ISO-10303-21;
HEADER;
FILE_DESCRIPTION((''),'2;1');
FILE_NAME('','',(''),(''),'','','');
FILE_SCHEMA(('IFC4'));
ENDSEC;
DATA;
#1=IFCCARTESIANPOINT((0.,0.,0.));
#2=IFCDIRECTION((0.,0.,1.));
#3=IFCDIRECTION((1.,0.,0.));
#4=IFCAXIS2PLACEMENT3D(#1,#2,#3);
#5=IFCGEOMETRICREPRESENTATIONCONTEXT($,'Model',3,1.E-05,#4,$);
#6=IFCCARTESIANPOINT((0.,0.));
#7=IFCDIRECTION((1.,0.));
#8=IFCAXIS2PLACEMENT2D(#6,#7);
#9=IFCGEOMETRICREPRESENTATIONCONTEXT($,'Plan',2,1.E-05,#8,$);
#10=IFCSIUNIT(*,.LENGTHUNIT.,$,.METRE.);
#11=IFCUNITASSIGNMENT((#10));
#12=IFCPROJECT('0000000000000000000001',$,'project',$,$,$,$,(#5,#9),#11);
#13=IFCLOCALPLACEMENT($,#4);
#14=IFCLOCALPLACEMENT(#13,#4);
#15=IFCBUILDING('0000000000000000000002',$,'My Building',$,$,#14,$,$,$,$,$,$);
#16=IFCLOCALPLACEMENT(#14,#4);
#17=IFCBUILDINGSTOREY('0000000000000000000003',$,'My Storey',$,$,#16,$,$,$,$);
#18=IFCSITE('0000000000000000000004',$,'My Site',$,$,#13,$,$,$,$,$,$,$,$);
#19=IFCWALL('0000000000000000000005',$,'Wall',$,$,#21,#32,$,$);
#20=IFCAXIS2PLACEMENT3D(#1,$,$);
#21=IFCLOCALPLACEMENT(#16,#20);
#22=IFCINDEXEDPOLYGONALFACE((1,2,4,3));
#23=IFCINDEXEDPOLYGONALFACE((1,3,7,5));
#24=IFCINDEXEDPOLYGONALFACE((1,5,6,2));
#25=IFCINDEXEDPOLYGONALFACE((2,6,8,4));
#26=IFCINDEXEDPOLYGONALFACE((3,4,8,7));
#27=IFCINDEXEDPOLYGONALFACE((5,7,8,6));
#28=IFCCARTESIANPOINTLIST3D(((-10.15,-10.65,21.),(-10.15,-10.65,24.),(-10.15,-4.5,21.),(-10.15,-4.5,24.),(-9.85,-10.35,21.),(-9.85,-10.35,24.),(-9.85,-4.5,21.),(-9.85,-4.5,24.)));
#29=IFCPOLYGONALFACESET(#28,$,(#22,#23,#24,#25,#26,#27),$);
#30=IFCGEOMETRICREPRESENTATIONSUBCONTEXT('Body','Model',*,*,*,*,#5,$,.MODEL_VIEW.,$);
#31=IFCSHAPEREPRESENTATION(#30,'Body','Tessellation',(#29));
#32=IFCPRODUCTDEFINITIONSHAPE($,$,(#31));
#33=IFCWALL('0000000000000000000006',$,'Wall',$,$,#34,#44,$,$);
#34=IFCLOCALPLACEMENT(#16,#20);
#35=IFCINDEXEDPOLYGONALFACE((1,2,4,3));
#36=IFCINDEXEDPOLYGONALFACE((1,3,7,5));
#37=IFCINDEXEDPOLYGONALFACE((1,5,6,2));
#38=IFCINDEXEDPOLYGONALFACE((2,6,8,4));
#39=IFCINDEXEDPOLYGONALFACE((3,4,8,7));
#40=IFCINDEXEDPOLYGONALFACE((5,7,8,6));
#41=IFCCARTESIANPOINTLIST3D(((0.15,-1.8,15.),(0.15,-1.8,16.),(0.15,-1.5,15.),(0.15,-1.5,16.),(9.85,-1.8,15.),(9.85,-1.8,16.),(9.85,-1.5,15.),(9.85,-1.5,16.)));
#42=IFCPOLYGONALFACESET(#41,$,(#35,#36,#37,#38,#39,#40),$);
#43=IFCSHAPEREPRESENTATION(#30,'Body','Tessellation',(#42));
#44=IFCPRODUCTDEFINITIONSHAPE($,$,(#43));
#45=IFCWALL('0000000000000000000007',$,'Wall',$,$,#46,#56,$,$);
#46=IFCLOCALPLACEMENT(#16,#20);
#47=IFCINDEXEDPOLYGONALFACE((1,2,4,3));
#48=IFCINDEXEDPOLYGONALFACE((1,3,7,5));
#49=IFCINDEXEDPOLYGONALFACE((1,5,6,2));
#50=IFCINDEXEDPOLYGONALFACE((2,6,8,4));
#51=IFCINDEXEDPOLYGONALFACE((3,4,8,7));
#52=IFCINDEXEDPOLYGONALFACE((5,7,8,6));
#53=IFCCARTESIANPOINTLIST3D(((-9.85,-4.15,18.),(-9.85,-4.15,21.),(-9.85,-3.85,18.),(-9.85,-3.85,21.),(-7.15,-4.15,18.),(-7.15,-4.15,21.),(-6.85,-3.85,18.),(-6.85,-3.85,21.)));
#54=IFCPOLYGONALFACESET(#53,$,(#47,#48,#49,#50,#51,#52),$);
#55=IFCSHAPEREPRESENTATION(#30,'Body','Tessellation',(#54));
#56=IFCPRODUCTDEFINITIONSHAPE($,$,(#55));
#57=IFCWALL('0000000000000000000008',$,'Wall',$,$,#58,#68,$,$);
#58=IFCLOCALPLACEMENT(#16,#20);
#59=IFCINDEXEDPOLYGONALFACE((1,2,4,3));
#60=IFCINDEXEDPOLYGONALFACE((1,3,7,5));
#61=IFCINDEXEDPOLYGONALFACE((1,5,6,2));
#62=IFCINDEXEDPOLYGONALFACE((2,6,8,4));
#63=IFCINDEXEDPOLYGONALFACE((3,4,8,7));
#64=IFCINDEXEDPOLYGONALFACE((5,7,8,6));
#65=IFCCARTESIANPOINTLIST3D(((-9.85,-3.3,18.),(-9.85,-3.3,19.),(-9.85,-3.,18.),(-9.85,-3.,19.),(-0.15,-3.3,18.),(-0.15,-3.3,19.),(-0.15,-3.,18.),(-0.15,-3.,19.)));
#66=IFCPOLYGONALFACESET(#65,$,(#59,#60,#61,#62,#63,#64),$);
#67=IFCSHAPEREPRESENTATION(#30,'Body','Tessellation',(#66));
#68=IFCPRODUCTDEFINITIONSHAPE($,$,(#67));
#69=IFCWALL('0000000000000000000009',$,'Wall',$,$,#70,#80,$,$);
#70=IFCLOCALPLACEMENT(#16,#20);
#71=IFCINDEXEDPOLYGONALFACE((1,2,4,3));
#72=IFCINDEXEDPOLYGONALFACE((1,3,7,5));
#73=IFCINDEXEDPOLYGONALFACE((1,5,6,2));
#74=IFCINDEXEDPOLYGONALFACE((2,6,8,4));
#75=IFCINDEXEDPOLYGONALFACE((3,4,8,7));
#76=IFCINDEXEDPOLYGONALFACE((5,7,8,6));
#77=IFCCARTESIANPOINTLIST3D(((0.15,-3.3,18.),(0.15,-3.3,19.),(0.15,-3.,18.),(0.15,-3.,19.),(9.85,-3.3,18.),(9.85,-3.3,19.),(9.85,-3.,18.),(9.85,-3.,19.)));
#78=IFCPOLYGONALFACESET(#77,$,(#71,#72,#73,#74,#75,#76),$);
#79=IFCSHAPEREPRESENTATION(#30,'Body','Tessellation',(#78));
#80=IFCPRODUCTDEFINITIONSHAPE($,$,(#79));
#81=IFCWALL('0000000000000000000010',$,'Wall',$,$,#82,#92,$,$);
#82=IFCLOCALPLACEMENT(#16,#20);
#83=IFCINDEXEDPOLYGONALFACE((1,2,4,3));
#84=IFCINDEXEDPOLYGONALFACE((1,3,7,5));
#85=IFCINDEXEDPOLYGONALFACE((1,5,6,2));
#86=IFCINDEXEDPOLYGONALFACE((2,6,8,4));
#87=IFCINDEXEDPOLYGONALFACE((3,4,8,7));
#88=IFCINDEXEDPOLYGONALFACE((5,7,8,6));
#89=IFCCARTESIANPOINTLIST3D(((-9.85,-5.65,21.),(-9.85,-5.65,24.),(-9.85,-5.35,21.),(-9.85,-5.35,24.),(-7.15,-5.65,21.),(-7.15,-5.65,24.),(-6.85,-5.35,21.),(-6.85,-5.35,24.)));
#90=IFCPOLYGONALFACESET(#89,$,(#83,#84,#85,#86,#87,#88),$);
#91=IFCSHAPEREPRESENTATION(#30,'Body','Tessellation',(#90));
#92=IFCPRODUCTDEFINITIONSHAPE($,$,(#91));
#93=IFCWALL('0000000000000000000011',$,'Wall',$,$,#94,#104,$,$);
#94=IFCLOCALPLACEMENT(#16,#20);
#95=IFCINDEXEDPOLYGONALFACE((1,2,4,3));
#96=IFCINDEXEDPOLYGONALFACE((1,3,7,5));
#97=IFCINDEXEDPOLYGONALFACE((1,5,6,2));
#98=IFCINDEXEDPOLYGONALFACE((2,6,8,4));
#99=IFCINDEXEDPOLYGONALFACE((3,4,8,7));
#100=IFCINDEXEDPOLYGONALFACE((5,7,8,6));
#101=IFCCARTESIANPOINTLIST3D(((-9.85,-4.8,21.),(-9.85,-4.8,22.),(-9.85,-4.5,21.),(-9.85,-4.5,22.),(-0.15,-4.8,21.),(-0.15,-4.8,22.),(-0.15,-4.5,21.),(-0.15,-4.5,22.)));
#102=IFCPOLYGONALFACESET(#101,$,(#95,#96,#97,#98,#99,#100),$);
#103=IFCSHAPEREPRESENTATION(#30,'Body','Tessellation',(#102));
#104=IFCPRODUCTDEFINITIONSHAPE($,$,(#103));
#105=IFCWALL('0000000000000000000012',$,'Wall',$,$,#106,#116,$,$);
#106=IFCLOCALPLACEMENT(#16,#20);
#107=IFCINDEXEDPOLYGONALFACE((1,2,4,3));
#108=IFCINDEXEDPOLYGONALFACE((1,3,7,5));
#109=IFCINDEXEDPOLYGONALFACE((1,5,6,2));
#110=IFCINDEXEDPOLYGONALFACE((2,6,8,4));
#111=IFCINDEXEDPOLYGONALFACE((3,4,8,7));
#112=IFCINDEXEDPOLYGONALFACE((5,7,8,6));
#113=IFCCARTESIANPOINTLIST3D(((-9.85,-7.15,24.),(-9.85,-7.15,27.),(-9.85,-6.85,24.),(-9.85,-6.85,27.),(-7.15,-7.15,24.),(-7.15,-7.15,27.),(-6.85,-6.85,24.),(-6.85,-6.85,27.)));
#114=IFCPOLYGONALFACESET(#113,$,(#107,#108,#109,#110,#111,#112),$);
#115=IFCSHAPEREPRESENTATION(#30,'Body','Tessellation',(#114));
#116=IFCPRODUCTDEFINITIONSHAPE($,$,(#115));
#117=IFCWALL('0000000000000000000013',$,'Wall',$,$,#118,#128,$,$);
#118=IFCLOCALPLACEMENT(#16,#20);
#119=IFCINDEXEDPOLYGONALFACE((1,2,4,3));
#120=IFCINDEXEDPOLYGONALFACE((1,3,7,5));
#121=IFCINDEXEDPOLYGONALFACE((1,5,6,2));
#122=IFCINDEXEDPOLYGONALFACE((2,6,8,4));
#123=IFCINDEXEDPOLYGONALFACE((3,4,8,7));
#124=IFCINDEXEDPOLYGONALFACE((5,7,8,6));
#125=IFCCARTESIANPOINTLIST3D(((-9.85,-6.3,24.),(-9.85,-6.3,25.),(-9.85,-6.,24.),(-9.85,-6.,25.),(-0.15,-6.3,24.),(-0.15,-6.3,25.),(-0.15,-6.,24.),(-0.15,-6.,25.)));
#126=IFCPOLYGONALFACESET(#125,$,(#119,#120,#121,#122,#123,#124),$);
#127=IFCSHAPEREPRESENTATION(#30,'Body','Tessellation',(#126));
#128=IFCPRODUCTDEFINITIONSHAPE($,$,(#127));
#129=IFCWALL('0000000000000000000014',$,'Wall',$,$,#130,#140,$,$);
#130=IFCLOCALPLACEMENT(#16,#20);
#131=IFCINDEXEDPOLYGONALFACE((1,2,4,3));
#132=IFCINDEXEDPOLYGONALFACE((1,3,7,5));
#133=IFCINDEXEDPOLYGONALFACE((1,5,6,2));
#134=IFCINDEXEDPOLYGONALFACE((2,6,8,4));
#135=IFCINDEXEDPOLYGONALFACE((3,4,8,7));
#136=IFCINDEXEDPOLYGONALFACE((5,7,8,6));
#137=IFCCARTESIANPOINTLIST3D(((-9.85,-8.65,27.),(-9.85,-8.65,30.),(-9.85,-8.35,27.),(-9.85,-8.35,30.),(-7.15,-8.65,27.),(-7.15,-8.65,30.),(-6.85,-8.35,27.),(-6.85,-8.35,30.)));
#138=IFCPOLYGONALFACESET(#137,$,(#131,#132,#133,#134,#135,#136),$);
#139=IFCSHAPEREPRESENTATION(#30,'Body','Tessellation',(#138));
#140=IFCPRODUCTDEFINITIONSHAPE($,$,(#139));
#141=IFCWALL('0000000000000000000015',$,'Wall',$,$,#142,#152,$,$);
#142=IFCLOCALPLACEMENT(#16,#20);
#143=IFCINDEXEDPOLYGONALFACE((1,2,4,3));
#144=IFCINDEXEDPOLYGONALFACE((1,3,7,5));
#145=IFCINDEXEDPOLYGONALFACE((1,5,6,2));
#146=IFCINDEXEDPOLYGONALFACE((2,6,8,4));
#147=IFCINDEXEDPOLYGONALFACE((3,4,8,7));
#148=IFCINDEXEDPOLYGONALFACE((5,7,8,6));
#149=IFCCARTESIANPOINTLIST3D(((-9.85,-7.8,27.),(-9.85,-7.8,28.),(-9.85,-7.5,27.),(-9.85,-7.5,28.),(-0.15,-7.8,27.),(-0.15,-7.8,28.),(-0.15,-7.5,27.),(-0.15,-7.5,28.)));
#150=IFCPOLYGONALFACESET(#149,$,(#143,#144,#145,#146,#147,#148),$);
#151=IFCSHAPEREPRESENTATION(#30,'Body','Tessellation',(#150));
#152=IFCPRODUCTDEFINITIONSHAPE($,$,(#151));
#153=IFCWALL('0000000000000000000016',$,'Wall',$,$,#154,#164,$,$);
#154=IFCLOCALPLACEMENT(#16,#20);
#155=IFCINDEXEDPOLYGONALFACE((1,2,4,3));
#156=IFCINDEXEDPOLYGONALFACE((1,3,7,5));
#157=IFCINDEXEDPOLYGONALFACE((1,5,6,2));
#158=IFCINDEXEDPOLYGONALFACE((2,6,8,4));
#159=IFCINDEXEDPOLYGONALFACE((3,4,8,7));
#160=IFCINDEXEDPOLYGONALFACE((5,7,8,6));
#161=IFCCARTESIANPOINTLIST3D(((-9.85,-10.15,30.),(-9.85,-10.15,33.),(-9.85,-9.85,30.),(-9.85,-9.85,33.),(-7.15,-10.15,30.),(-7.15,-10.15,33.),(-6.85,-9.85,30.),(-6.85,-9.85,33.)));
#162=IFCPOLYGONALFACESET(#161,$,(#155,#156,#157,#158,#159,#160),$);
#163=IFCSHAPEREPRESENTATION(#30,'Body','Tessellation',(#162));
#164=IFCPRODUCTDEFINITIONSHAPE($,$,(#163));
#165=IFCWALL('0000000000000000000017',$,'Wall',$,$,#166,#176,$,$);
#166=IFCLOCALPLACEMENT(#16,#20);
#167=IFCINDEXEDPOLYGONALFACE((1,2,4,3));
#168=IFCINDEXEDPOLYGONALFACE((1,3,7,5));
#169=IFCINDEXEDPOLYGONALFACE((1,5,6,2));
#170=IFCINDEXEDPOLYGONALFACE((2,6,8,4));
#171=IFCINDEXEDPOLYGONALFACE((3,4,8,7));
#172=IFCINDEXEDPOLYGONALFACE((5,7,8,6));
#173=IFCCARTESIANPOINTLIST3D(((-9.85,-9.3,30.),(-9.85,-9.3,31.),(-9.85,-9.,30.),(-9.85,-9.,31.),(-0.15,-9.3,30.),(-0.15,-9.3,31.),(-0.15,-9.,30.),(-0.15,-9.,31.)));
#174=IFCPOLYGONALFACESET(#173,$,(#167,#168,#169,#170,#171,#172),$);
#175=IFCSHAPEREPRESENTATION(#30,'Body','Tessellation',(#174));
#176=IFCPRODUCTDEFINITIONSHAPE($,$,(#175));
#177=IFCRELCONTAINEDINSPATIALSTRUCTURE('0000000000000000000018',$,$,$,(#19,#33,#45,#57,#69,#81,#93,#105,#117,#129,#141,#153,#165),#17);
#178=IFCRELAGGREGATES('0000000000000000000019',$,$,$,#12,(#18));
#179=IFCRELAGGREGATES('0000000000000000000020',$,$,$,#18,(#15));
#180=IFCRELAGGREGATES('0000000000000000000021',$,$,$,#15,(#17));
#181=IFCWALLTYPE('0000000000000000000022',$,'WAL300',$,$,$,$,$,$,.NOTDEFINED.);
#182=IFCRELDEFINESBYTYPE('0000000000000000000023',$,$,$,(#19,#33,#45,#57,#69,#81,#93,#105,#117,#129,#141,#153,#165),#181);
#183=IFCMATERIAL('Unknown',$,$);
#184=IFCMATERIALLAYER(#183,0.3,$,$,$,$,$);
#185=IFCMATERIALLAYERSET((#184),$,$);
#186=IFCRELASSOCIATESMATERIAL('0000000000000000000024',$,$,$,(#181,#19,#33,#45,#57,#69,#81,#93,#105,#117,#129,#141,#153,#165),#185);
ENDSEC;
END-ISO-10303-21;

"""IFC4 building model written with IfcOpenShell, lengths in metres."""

from ifc_helpers import new_model, si_unit, frame, origin_with_axes, origin_2d_with_axis, place, context, subcontext, project, spatial, line, indexed_curve, outline, extrude, material, layer, layer_set, layer_usage, type_object, element, save


model = new_model("IFC4")

# Units and contexts
model_context = context("Model", 3, precision=1e-05, world=origin_with_axes())
plan_context = context("Plan", 2, precision=1e-05, world=origin_2d_with_axis())
body_context = subcontext(model_context, "Body", "Model", "MODEL_VIEW")
ifc_project = project(units=[si_unit("LENGTHUNIT", "METRE")], contexts=[model_context, plan_context])

# Site, building, storey
site_placement = place(None, origin_with_axes())
site = spatial("IfcSite", under=ifc_project, at=site_placement, Name="My Site")
building_placement = place(site_placement, origin_with_axes())
building = spatial("IfcBuilding", under=site, at=building_placement, Name="My Building")
storey_placement = place(building_placement, origin_with_axes())
storey = spatial("IfcBuildingStorey", under=building, at=storey_placement, Name="My Storey")

# Walls
ifc_material = material(Name="Unknown")
ifc_layer = layer(ifc_material, 0.3)
ifc_layer_set = layer_set([ifc_layer])
wall_type = type_object("IfcWallType", Name="WAL300", PredefinedType="NOTDEFINED", material=ifc_layer_set)
ifc_layer_usage_1 = layer_usage(ifc_layer_set, "AXIS2", "POSITIVE", -0.15)
wall_1_placement = place(storey_placement, frame((-10.0, -10.5, 21.0), z_axis=(0.0, 0.0, 1.0), x_axis=(0.0, 1.0, 0.0)))
element("IfcWall", 1, at=wall_1_placement, inside=storey, type_object=wall_type, material=ifc_layer_usage_1, Name="Wall", context=body_context, shape_type="SweptSolid", body=[
    extrude(outline(indexed_curve([(0.15, -0.15), (-0.15, 0.15), (6.0, 0.15), (6.0, -0.15)], segments=[line(1, 2, 3, 4, 1)])), origin_with_axes(), (0.0, 0.0, 1.0), 3.0),
])
ifc_layer_usage_2 = layer_usage(ifc_layer_set, "AXIS2", "POSITIVE", -0.3)
wall_2_placement = place(storey_placement, frame((0.15, -1.5, 15.0), z_axis=(0.0, 0.0, 1.0), x_axis=(1.0, 0.0, 0.0)))
element("IfcWall", 2, at=wall_2_placement, inside=storey, type_object=wall_type, material=ifc_layer_usage_2, Name="Wall", context=body_context, shape_type="SweptSolid", body=[
    extrude(outline(indexed_curve([(0.0, -0.3), (0.0, 0.0), (9.7, 0.0), (9.7, -0.3)], segments=[line(1, 2, 3, 4, 1)])), origin_with_axes(), (0.0, 0.0, 1.0), 1.0),
])
ifc_layer_usage_3 = layer_usage(ifc_layer_set, "AXIS2", "POSITIVE", -0.15)
wall_3_placement = place(storey_placement, frame((-10.0, -4.0, 18.0), z_axis=(0.0, 0.0, 1.0), x_axis=(1.0, 0.0, 0.0)))
element("IfcWall", 3, at=wall_3_placement, inside=storey, type_object=wall_type, material=ifc_layer_usage_3, Name="Wall", context=body_context, shape_type="SweptSolid", body=[
    extrude(outline(indexed_curve([(0.15, -0.15), (0.15, 0.15), (3.15, 0.15), (2.85, -0.15)], segments=[line(1, 2, 3, 4, 1)])), origin_with_axes(), (0.0, 0.0, 1.0), 3.0),
])
ifc_layer_usage_4 = layer_usage(ifc_layer_set, "AXIS2", "POSITIVE", -0.3)
wall_4_placement = place(storey_placement, frame((-9.85, -3.0, 18.0), z_axis=(0.0, 0.0, 1.0), x_axis=(1.0, 0.0, 0.0)))
element("IfcWall", 4, at=wall_4_placement, inside=storey, type_object=wall_type, material=ifc_layer_usage_4, Name="Wall", context=body_context, shape_type="SweptSolid", body=[
    extrude(outline(indexed_curve([(0.0, -0.3), (0.0, 0.0), (9.7, 0.0), (9.7, -0.3)], segments=[line(1, 2, 3, 4, 1)])), origin_with_axes(), (0.0, 0.0, 1.0), 1.0),
])
ifc_layer_usage_5 = layer_usage(ifc_layer_set, "AXIS2", "POSITIVE", -0.3)
wall_5_placement = place(storey_placement, frame((0.15, -3.0, 18.0), z_axis=(0.0, 0.0, 1.0), x_axis=(1.0, 0.0, 0.0)))
element("IfcWall", 5, at=wall_5_placement, inside=storey, type_object=wall_type, material=ifc_layer_usage_5, Name="Wall", context=body_context, shape_type="SweptSolid", body=[
    extrude(outline(indexed_curve([(0.0, -0.3), (0.0, 0.0), (9.7, 0.0), (9.7, -0.3)], segments=[line(1, 2, 3, 4, 1)])), origin_with_axes(), (0.0, 0.0, 1.0), 1.0),
])
ifc_layer_usage_6 = layer_usage(ifc_layer_set, "AXIS2", "POSITIVE", -0.15)
wall_6_placement = place(storey_placement, frame((-10.0, -5.5, 21.0), z_axis=(0.0, 0.0, 1.0), x_axis=(1.0, 0.0, 0.0)))
element("IfcWall", 6, at=wall_6_placement, inside=storey, type_object=wall_type, material=ifc_layer_usage_6, Name="Wall", context=body_context, shape_type="SweptSolid", body=[
    extrude(outline(indexed_curve([(0.15, -0.15), (0.15, 0.15), (3.15, 0.15), (2.85, -0.15)], segments=[line(1, 2, 3, 4, 1)])), origin_with_axes(), (0.0, 0.0, 1.0), 3.0),
])
ifc_layer_usage_7 = layer_usage(ifc_layer_set, "AXIS2", "POSITIVE", -0.3)
wall_7_placement = place(storey_placement, frame((-9.85, -4.5, 21.0), z_axis=(0.0, 0.0, 1.0), x_axis=(1.0, 0.0, 0.0)))
element("IfcWall", 7, at=wall_7_placement, inside=storey, type_object=wall_type, material=ifc_layer_usage_7, Name="Wall", context=body_context, shape_type="SweptSolid", body=[
    extrude(outline(indexed_curve([(0.0, -0.3), (0.0, 0.0), (9.7, 0.0), (9.7, -0.3)], segments=[line(1, 2, 3, 4, 1)])), origin_with_axes(), (0.0, 0.0, 1.0), 1.0),
])
ifc_layer_usage_8 = layer_usage(ifc_layer_set, "AXIS2", "POSITIVE", -0.15)
wall_8_placement = place(storey_placement, frame((-10.0, -7.0, 24.0), z_axis=(0.0, 0.0, 1.0), x_axis=(1.0, 0.0, 0.0)))
element("IfcWall", 8, at=wall_8_placement, inside=storey, type_object=wall_type, material=ifc_layer_usage_8, Name="Wall", context=body_context, shape_type="SweptSolid", body=[
    extrude(outline(indexed_curve([(0.15, -0.15), (0.15, 0.15), (3.15, 0.15), (2.85, -0.15)], segments=[line(1, 2, 3, 4, 1)])), origin_with_axes(), (0.0, 0.0, 1.0), 3.0),
])
ifc_layer_usage_9 = layer_usage(ifc_layer_set, "AXIS2", "POSITIVE", -0.3)
wall_9_placement = place(storey_placement, frame((-9.85, -6.0, 24.0), z_axis=(0.0, 0.0, 1.0), x_axis=(1.0, 0.0, 0.0)))
element("IfcWall", 9, at=wall_9_placement, inside=storey, type_object=wall_type, material=ifc_layer_usage_9, Name="Wall", context=body_context, shape_type="SweptSolid", body=[
    extrude(outline(indexed_curve([(0.0, -0.3), (0.0, 0.0), (9.7, 0.0), (9.7, -0.3)], segments=[line(1, 2, 3, 4, 1)])), origin_with_axes(), (0.0, 0.0, 1.0), 1.0),
])
ifc_layer_usage_10 = layer_usage(ifc_layer_set, "AXIS2", "POSITIVE", -0.15)
wall_10_placement = place(storey_placement, frame((-10.0, -8.5, 27.0), z_axis=(0.0, 0.0, 1.0), x_axis=(1.0, 0.0, 0.0)))
element("IfcWall", 10, at=wall_10_placement, inside=storey, type_object=wall_type, material=ifc_layer_usage_10, Name="Wall", context=body_context, shape_type="SweptSolid", body=[
    extrude(outline(indexed_curve([(0.15, -0.15), (0.15, 0.15), (3.15, 0.15), (2.85, -0.15)], segments=[line(1, 2, 3, 4, 1)])), origin_with_axes(), (0.0, 0.0, 1.0), 3.0),
])
ifc_layer_usage_11 = layer_usage(ifc_layer_set, "AXIS2", "POSITIVE", -0.3)
wall_11_placement = place(storey_placement, frame((-9.85, -7.5, 27.0), z_axis=(0.0, 0.0, 1.0), x_axis=(1.0, 0.0, 0.0)))
element("IfcWall", 11, at=wall_11_placement, inside=storey, type_object=wall_type, material=ifc_layer_usage_11, Name="Wall", context=body_context, shape_type="SweptSolid", body=[
    extrude(outline(indexed_curve([(0.0, -0.3), (0.0, 0.0), (9.7, 0.0), (9.7, -0.3)], segments=[line(1, 2, 3, 4, 1)])), origin_with_axes(), (0.0, 0.0, 1.0), 1.0),
])
ifc_layer_usage_12 = layer_usage(ifc_layer_set, "AXIS2", "POSITIVE", -0.15)
wall_12_placement = place(storey_placement, frame((-10.0, -10.0, 30.0), z_axis=(0.0, 0.0, 1.0), x_axis=(1.0, 0.0, 0.0)))
element("IfcWall", 12, at=wall_12_placement, inside=storey, type_object=wall_type, material=ifc_layer_usage_12, Name="Wall", context=body_context, shape_type="SweptSolid", body=[
    extrude(outline(indexed_curve([(0.15, -0.15), (0.15, 0.15), (3.15, 0.15), (2.85, -0.15)], segments=[line(1, 2, 3, 4, 1)])), origin_with_axes(), (0.0, 0.0, 1.0), 3.0),
])
ifc_layer_usage_13 = layer_usage(ifc_layer_set, "AXIS2", "POSITIVE", -0.3)
wall_13_placement = place(storey_placement, frame((-9.85, -9.0, 30.0), z_axis=(0.0, 0.0, 1.0), x_axis=(1.0, 0.0, 0.0)))
element("IfcWall", 13, at=wall_13_placement, inside=storey, type_object=wall_type, material=ifc_layer_usage_13, Name="Wall", context=body_context, shape_type="SweptSolid", body=[
    extrude(outline(indexed_curve([(0.0, -0.3), (0.0, 0.0), (9.7, 0.0), (9.7, -0.3)], segments=[line(1, 2, 3, 4, 1)])), origin_with_axes(), (0.0, 0.0, 1.0), 1.0),
])

save(model, "model.ifc")
